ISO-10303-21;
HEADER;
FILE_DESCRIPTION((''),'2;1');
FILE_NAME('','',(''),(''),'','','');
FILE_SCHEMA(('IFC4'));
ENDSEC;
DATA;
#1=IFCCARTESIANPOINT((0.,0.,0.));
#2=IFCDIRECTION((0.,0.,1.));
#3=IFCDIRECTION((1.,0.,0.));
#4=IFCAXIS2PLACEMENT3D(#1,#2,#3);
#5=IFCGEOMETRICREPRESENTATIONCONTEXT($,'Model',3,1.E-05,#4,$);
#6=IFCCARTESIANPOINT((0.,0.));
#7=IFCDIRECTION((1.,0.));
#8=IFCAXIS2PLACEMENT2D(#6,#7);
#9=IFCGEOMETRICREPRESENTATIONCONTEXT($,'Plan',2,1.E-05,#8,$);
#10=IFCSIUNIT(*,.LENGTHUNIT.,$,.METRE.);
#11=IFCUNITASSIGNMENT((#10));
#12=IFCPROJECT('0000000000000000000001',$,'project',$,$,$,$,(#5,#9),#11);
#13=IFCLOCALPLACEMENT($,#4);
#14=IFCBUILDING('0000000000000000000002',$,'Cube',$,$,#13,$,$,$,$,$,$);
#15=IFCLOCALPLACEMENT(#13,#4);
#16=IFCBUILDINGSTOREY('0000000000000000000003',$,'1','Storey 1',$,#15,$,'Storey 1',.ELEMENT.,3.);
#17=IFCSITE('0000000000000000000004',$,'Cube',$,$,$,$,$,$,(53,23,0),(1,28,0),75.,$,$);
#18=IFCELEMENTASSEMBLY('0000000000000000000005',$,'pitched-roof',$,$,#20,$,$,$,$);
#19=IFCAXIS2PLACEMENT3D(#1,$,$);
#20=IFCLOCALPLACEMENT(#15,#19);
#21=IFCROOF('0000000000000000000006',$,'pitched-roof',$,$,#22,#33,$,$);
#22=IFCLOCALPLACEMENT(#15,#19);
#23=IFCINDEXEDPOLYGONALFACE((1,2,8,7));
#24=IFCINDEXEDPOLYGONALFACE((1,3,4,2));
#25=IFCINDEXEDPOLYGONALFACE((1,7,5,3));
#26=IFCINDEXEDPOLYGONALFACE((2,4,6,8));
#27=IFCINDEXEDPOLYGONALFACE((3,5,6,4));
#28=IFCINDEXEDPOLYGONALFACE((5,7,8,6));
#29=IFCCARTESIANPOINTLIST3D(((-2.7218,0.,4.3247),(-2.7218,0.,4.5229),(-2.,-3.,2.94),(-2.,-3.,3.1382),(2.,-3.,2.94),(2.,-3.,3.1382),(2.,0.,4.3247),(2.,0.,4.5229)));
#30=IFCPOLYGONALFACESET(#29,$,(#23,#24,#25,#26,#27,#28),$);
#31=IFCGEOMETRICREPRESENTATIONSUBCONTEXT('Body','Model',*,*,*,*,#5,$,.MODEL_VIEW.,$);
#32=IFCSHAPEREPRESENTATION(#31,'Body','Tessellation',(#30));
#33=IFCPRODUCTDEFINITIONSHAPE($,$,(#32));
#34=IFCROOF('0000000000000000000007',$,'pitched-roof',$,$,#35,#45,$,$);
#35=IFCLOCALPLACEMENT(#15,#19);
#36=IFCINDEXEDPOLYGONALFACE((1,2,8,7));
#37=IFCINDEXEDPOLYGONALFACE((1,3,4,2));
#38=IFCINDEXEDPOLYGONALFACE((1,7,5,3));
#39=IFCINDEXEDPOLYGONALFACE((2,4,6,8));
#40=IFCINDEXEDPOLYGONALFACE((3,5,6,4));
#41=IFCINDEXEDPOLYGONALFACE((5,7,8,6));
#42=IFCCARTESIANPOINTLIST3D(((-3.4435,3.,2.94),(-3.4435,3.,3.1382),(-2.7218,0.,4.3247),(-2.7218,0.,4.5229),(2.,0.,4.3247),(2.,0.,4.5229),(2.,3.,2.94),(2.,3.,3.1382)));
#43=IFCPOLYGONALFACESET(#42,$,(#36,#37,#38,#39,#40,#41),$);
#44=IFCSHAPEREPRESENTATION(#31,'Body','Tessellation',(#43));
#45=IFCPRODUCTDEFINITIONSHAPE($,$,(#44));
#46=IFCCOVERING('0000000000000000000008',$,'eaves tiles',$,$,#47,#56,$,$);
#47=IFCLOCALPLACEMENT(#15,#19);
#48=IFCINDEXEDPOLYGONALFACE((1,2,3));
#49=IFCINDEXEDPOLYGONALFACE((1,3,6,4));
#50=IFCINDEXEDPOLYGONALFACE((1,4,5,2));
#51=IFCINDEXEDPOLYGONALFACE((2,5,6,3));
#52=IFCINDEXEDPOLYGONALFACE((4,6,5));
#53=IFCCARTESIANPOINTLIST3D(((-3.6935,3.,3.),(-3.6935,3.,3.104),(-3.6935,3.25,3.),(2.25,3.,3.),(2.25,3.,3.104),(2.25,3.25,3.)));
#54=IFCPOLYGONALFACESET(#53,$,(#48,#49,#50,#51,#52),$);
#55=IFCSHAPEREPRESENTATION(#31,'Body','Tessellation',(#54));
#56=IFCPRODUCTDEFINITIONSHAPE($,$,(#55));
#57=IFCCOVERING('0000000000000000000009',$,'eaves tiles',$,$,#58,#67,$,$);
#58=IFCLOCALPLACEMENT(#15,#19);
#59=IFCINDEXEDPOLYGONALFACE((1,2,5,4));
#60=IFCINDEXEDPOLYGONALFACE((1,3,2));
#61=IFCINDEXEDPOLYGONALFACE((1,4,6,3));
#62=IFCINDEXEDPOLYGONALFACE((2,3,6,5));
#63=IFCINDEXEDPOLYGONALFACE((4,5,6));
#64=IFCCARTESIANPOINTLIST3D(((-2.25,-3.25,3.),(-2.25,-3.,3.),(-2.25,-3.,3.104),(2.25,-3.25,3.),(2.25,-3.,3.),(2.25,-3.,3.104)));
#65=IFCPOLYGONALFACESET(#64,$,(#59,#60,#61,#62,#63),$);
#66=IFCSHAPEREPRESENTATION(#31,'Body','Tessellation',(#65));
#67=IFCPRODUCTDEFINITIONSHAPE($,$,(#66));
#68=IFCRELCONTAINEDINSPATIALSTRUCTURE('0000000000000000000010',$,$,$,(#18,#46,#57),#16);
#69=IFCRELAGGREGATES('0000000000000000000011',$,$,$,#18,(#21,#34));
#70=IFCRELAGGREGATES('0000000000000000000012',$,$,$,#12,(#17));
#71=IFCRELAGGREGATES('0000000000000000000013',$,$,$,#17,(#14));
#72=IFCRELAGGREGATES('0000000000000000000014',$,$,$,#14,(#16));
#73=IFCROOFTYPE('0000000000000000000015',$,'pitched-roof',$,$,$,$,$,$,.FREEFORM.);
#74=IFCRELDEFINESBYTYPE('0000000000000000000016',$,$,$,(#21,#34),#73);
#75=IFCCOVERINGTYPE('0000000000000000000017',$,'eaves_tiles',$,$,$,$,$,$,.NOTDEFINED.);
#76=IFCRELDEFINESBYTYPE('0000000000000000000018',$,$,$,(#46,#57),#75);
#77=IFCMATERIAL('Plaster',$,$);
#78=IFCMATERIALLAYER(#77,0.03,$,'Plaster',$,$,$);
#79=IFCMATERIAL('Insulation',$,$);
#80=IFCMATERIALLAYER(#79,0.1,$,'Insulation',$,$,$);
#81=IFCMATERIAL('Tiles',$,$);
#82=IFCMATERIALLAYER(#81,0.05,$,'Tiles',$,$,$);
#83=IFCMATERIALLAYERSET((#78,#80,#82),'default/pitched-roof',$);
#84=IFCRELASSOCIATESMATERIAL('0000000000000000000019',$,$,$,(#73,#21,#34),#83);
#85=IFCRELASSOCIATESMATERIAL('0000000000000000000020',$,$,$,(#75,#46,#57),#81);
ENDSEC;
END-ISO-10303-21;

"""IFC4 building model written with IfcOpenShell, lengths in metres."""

from ifc_helpers import new_model, si_unit, frame, origin, origin_with_axes, origin_2d_with_axis, place, context, subcontext, project, spatial, polyline, outline, extrude, material, layer, layer_set, layer_usage, material_profile, profile_set, profile_usage, type_object, element, aggregate, save


model = new_model("IFC4")

# Units and contexts
model_context = context("Model", 3, precision=1e-05, world=origin_with_axes())
plan_context = context("Plan", 2, precision=1e-05, world=origin_2d_with_axis())
body_context = subcontext(model_context, "Body", "Model", "MODEL_VIEW")
ifc_project = project(units=[si_unit("LENGTHUNIT", "METRE")], contexts=[model_context, plan_context])

# Site, building, storey
site = spatial("IfcSite", under=ifc_project, Name="Cube", RefLatitude=(53, 23, 0), RefLongitude=(1, 28, 0), RefElevation=75.0)
building_placement = place(None, origin_with_axes())
building = spatial("IfcBuilding", under=site, at=building_placement, Name="Cube")
storey_placement = place(building_placement, origin_with_axes())
storey = spatial("IfcBuildingStorey", under=building, at=storey_placement, Name="1", Description="Storey 1", LongName="Storey 1", CompositionType="ELEMENT", Elevation=3.0)

# Element assembly, roofs
assembly_placement = place(storey_placement, origin_with_axes())
assembly = element("IfcElementAssembly", 1, at=assembly_placement, inside=storey, Name="pitched-roof")
ifc_material_1 = material(Name="Plaster")
ifc_layer_1 = layer(ifc_material_1, 0.03, Name="Plaster")
ifc_material_2 = material(Name="Insulation")
ifc_layer_2 = layer(ifc_material_2, 0.1, Name="Insulation")
ifc_material_3 = material(Name="Tiles")
ifc_layer_3 = layer(ifc_material_3, 0.05, Name="Tiles")
ifc_layer_set = layer_set([ifc_layer_1, ifc_layer_2, ifc_layer_3], Name="default/pitched-roof")
ifc_layer_usage_1 = layer_usage(ifc_layer_set, "AXIS3", "POSITIVE", 0.0)
roof_type = type_object("IfcRoofType", Name="pitched-roof", PredefinedType="FREEFORM", material=ifc_layer_set)
roof_1_placement = place(assembly_placement, frame((-2.0, -3.0, 2.94), z_axis=(0.0, -0.419069, 0.907954), x_axis=(1.0, 0.0, 0.0)))
roof_1 = element("IfcRoof", 2, at=roof_1_placement, type_object=roof_type, material=ifc_layer_usage_1, Name="pitched-roof", context=body_context, shape_type="SweptSolid", body=[
    extrude(outline(polyline([(0.0, 0.0), (4.0, 0.0), (4.0, 3.3041), (-0.7218, 3.3041), (0.0, 0.0)])), origin(), (0.0, 0.419069, 0.907954), 0.1982),
])
ifc_layer_usage_2 = layer_usage(ifc_layer_set, "AXIS3", "POSITIVE", 0.0)
roof_2_placement = place(assembly_placement, frame((-3.4435, 3.0, 2.94), z_axis=(0.0, 0.419069, 0.907954), x_axis=(-1.0, 0.0, 0.0)))
roof_2 = element("IfcRoof", 3, at=roof_2_placement, type_object=roof_type, material=ifc_layer_usage_2, Name="pitched-roof", context=body_context, shape_type="SweptSolid", body=[
    extrude(outline(polyline([(0.0, 0.0), (-0.7218, 3.3041), (-5.4435, 3.3041), (-5.4435, 0.0), (0.0, 0.0)])), origin(), (0.0, 0.419069, 0.907954), 0.1982),
])
aggregate(assembly, [roof_1, roof_2])

# Coverings
ifc_material_profile_1 = material_profile(ifc_material_3, outline(polyline([(0.25, 0.0), (0.0, 0.0), (0.0, 0.104), (0.25, 0.0)])))
ifc_profile_set_1 = profile_set([ifc_material_profile_1])
ifc_profile_usage_1 = profile_usage(ifc_profile_set_1)
covering_type_1 = type_object("IfcCoveringType", Name="eaves_tiles", PredefinedType="NOTDEFINED", material=ifc_profile_set_1)
covering_1_placement = place(storey_placement, frame((-3.6935, 3.0, 3.0), z_axis=(1.0, 0.0, 0.0), x_axis=(0.0, 1.0, 0.0)))
element("IfcCovering", 4, at=covering_1_placement, inside=storey, type_object=covering_type_1, material=ifc_profile_usage_1, Name="eaves tiles", context=body_context, shape_type="SweptSolid", body=[
    extrude(outline(polyline([(0.25, 0.0), (0.0, 0.0), (0.0, 0.104), (0.25, 0.0)])), origin_with_axes(), (0.0, 0.0, 1.0), 5.9435),
])
ifc_profile_usage_2 = profile_usage(ifc_profile_set_1)
covering_2_placement = place(storey_placement, frame((2.25, -3.0, 3.0), z_axis=(-1.0, 0.0, 0.0), x_axis=(0.0, -1.0, 0.0)))
element("IfcCovering", 5, at=covering_2_placement, inside=storey, type_object=covering_type_1, material=ifc_profile_usage_2, Name="eaves tiles", context=body_context, shape_type="SweptSolid", body=[
    extrude(outline(polyline([(0.25, 0.0), (0.0, 0.0), (0.0, 0.104), (0.25, 0.0)])), origin_with_axes(), (0.0, 0.0, 1.0), 4.5),
])

save(model, "model.ifc")
